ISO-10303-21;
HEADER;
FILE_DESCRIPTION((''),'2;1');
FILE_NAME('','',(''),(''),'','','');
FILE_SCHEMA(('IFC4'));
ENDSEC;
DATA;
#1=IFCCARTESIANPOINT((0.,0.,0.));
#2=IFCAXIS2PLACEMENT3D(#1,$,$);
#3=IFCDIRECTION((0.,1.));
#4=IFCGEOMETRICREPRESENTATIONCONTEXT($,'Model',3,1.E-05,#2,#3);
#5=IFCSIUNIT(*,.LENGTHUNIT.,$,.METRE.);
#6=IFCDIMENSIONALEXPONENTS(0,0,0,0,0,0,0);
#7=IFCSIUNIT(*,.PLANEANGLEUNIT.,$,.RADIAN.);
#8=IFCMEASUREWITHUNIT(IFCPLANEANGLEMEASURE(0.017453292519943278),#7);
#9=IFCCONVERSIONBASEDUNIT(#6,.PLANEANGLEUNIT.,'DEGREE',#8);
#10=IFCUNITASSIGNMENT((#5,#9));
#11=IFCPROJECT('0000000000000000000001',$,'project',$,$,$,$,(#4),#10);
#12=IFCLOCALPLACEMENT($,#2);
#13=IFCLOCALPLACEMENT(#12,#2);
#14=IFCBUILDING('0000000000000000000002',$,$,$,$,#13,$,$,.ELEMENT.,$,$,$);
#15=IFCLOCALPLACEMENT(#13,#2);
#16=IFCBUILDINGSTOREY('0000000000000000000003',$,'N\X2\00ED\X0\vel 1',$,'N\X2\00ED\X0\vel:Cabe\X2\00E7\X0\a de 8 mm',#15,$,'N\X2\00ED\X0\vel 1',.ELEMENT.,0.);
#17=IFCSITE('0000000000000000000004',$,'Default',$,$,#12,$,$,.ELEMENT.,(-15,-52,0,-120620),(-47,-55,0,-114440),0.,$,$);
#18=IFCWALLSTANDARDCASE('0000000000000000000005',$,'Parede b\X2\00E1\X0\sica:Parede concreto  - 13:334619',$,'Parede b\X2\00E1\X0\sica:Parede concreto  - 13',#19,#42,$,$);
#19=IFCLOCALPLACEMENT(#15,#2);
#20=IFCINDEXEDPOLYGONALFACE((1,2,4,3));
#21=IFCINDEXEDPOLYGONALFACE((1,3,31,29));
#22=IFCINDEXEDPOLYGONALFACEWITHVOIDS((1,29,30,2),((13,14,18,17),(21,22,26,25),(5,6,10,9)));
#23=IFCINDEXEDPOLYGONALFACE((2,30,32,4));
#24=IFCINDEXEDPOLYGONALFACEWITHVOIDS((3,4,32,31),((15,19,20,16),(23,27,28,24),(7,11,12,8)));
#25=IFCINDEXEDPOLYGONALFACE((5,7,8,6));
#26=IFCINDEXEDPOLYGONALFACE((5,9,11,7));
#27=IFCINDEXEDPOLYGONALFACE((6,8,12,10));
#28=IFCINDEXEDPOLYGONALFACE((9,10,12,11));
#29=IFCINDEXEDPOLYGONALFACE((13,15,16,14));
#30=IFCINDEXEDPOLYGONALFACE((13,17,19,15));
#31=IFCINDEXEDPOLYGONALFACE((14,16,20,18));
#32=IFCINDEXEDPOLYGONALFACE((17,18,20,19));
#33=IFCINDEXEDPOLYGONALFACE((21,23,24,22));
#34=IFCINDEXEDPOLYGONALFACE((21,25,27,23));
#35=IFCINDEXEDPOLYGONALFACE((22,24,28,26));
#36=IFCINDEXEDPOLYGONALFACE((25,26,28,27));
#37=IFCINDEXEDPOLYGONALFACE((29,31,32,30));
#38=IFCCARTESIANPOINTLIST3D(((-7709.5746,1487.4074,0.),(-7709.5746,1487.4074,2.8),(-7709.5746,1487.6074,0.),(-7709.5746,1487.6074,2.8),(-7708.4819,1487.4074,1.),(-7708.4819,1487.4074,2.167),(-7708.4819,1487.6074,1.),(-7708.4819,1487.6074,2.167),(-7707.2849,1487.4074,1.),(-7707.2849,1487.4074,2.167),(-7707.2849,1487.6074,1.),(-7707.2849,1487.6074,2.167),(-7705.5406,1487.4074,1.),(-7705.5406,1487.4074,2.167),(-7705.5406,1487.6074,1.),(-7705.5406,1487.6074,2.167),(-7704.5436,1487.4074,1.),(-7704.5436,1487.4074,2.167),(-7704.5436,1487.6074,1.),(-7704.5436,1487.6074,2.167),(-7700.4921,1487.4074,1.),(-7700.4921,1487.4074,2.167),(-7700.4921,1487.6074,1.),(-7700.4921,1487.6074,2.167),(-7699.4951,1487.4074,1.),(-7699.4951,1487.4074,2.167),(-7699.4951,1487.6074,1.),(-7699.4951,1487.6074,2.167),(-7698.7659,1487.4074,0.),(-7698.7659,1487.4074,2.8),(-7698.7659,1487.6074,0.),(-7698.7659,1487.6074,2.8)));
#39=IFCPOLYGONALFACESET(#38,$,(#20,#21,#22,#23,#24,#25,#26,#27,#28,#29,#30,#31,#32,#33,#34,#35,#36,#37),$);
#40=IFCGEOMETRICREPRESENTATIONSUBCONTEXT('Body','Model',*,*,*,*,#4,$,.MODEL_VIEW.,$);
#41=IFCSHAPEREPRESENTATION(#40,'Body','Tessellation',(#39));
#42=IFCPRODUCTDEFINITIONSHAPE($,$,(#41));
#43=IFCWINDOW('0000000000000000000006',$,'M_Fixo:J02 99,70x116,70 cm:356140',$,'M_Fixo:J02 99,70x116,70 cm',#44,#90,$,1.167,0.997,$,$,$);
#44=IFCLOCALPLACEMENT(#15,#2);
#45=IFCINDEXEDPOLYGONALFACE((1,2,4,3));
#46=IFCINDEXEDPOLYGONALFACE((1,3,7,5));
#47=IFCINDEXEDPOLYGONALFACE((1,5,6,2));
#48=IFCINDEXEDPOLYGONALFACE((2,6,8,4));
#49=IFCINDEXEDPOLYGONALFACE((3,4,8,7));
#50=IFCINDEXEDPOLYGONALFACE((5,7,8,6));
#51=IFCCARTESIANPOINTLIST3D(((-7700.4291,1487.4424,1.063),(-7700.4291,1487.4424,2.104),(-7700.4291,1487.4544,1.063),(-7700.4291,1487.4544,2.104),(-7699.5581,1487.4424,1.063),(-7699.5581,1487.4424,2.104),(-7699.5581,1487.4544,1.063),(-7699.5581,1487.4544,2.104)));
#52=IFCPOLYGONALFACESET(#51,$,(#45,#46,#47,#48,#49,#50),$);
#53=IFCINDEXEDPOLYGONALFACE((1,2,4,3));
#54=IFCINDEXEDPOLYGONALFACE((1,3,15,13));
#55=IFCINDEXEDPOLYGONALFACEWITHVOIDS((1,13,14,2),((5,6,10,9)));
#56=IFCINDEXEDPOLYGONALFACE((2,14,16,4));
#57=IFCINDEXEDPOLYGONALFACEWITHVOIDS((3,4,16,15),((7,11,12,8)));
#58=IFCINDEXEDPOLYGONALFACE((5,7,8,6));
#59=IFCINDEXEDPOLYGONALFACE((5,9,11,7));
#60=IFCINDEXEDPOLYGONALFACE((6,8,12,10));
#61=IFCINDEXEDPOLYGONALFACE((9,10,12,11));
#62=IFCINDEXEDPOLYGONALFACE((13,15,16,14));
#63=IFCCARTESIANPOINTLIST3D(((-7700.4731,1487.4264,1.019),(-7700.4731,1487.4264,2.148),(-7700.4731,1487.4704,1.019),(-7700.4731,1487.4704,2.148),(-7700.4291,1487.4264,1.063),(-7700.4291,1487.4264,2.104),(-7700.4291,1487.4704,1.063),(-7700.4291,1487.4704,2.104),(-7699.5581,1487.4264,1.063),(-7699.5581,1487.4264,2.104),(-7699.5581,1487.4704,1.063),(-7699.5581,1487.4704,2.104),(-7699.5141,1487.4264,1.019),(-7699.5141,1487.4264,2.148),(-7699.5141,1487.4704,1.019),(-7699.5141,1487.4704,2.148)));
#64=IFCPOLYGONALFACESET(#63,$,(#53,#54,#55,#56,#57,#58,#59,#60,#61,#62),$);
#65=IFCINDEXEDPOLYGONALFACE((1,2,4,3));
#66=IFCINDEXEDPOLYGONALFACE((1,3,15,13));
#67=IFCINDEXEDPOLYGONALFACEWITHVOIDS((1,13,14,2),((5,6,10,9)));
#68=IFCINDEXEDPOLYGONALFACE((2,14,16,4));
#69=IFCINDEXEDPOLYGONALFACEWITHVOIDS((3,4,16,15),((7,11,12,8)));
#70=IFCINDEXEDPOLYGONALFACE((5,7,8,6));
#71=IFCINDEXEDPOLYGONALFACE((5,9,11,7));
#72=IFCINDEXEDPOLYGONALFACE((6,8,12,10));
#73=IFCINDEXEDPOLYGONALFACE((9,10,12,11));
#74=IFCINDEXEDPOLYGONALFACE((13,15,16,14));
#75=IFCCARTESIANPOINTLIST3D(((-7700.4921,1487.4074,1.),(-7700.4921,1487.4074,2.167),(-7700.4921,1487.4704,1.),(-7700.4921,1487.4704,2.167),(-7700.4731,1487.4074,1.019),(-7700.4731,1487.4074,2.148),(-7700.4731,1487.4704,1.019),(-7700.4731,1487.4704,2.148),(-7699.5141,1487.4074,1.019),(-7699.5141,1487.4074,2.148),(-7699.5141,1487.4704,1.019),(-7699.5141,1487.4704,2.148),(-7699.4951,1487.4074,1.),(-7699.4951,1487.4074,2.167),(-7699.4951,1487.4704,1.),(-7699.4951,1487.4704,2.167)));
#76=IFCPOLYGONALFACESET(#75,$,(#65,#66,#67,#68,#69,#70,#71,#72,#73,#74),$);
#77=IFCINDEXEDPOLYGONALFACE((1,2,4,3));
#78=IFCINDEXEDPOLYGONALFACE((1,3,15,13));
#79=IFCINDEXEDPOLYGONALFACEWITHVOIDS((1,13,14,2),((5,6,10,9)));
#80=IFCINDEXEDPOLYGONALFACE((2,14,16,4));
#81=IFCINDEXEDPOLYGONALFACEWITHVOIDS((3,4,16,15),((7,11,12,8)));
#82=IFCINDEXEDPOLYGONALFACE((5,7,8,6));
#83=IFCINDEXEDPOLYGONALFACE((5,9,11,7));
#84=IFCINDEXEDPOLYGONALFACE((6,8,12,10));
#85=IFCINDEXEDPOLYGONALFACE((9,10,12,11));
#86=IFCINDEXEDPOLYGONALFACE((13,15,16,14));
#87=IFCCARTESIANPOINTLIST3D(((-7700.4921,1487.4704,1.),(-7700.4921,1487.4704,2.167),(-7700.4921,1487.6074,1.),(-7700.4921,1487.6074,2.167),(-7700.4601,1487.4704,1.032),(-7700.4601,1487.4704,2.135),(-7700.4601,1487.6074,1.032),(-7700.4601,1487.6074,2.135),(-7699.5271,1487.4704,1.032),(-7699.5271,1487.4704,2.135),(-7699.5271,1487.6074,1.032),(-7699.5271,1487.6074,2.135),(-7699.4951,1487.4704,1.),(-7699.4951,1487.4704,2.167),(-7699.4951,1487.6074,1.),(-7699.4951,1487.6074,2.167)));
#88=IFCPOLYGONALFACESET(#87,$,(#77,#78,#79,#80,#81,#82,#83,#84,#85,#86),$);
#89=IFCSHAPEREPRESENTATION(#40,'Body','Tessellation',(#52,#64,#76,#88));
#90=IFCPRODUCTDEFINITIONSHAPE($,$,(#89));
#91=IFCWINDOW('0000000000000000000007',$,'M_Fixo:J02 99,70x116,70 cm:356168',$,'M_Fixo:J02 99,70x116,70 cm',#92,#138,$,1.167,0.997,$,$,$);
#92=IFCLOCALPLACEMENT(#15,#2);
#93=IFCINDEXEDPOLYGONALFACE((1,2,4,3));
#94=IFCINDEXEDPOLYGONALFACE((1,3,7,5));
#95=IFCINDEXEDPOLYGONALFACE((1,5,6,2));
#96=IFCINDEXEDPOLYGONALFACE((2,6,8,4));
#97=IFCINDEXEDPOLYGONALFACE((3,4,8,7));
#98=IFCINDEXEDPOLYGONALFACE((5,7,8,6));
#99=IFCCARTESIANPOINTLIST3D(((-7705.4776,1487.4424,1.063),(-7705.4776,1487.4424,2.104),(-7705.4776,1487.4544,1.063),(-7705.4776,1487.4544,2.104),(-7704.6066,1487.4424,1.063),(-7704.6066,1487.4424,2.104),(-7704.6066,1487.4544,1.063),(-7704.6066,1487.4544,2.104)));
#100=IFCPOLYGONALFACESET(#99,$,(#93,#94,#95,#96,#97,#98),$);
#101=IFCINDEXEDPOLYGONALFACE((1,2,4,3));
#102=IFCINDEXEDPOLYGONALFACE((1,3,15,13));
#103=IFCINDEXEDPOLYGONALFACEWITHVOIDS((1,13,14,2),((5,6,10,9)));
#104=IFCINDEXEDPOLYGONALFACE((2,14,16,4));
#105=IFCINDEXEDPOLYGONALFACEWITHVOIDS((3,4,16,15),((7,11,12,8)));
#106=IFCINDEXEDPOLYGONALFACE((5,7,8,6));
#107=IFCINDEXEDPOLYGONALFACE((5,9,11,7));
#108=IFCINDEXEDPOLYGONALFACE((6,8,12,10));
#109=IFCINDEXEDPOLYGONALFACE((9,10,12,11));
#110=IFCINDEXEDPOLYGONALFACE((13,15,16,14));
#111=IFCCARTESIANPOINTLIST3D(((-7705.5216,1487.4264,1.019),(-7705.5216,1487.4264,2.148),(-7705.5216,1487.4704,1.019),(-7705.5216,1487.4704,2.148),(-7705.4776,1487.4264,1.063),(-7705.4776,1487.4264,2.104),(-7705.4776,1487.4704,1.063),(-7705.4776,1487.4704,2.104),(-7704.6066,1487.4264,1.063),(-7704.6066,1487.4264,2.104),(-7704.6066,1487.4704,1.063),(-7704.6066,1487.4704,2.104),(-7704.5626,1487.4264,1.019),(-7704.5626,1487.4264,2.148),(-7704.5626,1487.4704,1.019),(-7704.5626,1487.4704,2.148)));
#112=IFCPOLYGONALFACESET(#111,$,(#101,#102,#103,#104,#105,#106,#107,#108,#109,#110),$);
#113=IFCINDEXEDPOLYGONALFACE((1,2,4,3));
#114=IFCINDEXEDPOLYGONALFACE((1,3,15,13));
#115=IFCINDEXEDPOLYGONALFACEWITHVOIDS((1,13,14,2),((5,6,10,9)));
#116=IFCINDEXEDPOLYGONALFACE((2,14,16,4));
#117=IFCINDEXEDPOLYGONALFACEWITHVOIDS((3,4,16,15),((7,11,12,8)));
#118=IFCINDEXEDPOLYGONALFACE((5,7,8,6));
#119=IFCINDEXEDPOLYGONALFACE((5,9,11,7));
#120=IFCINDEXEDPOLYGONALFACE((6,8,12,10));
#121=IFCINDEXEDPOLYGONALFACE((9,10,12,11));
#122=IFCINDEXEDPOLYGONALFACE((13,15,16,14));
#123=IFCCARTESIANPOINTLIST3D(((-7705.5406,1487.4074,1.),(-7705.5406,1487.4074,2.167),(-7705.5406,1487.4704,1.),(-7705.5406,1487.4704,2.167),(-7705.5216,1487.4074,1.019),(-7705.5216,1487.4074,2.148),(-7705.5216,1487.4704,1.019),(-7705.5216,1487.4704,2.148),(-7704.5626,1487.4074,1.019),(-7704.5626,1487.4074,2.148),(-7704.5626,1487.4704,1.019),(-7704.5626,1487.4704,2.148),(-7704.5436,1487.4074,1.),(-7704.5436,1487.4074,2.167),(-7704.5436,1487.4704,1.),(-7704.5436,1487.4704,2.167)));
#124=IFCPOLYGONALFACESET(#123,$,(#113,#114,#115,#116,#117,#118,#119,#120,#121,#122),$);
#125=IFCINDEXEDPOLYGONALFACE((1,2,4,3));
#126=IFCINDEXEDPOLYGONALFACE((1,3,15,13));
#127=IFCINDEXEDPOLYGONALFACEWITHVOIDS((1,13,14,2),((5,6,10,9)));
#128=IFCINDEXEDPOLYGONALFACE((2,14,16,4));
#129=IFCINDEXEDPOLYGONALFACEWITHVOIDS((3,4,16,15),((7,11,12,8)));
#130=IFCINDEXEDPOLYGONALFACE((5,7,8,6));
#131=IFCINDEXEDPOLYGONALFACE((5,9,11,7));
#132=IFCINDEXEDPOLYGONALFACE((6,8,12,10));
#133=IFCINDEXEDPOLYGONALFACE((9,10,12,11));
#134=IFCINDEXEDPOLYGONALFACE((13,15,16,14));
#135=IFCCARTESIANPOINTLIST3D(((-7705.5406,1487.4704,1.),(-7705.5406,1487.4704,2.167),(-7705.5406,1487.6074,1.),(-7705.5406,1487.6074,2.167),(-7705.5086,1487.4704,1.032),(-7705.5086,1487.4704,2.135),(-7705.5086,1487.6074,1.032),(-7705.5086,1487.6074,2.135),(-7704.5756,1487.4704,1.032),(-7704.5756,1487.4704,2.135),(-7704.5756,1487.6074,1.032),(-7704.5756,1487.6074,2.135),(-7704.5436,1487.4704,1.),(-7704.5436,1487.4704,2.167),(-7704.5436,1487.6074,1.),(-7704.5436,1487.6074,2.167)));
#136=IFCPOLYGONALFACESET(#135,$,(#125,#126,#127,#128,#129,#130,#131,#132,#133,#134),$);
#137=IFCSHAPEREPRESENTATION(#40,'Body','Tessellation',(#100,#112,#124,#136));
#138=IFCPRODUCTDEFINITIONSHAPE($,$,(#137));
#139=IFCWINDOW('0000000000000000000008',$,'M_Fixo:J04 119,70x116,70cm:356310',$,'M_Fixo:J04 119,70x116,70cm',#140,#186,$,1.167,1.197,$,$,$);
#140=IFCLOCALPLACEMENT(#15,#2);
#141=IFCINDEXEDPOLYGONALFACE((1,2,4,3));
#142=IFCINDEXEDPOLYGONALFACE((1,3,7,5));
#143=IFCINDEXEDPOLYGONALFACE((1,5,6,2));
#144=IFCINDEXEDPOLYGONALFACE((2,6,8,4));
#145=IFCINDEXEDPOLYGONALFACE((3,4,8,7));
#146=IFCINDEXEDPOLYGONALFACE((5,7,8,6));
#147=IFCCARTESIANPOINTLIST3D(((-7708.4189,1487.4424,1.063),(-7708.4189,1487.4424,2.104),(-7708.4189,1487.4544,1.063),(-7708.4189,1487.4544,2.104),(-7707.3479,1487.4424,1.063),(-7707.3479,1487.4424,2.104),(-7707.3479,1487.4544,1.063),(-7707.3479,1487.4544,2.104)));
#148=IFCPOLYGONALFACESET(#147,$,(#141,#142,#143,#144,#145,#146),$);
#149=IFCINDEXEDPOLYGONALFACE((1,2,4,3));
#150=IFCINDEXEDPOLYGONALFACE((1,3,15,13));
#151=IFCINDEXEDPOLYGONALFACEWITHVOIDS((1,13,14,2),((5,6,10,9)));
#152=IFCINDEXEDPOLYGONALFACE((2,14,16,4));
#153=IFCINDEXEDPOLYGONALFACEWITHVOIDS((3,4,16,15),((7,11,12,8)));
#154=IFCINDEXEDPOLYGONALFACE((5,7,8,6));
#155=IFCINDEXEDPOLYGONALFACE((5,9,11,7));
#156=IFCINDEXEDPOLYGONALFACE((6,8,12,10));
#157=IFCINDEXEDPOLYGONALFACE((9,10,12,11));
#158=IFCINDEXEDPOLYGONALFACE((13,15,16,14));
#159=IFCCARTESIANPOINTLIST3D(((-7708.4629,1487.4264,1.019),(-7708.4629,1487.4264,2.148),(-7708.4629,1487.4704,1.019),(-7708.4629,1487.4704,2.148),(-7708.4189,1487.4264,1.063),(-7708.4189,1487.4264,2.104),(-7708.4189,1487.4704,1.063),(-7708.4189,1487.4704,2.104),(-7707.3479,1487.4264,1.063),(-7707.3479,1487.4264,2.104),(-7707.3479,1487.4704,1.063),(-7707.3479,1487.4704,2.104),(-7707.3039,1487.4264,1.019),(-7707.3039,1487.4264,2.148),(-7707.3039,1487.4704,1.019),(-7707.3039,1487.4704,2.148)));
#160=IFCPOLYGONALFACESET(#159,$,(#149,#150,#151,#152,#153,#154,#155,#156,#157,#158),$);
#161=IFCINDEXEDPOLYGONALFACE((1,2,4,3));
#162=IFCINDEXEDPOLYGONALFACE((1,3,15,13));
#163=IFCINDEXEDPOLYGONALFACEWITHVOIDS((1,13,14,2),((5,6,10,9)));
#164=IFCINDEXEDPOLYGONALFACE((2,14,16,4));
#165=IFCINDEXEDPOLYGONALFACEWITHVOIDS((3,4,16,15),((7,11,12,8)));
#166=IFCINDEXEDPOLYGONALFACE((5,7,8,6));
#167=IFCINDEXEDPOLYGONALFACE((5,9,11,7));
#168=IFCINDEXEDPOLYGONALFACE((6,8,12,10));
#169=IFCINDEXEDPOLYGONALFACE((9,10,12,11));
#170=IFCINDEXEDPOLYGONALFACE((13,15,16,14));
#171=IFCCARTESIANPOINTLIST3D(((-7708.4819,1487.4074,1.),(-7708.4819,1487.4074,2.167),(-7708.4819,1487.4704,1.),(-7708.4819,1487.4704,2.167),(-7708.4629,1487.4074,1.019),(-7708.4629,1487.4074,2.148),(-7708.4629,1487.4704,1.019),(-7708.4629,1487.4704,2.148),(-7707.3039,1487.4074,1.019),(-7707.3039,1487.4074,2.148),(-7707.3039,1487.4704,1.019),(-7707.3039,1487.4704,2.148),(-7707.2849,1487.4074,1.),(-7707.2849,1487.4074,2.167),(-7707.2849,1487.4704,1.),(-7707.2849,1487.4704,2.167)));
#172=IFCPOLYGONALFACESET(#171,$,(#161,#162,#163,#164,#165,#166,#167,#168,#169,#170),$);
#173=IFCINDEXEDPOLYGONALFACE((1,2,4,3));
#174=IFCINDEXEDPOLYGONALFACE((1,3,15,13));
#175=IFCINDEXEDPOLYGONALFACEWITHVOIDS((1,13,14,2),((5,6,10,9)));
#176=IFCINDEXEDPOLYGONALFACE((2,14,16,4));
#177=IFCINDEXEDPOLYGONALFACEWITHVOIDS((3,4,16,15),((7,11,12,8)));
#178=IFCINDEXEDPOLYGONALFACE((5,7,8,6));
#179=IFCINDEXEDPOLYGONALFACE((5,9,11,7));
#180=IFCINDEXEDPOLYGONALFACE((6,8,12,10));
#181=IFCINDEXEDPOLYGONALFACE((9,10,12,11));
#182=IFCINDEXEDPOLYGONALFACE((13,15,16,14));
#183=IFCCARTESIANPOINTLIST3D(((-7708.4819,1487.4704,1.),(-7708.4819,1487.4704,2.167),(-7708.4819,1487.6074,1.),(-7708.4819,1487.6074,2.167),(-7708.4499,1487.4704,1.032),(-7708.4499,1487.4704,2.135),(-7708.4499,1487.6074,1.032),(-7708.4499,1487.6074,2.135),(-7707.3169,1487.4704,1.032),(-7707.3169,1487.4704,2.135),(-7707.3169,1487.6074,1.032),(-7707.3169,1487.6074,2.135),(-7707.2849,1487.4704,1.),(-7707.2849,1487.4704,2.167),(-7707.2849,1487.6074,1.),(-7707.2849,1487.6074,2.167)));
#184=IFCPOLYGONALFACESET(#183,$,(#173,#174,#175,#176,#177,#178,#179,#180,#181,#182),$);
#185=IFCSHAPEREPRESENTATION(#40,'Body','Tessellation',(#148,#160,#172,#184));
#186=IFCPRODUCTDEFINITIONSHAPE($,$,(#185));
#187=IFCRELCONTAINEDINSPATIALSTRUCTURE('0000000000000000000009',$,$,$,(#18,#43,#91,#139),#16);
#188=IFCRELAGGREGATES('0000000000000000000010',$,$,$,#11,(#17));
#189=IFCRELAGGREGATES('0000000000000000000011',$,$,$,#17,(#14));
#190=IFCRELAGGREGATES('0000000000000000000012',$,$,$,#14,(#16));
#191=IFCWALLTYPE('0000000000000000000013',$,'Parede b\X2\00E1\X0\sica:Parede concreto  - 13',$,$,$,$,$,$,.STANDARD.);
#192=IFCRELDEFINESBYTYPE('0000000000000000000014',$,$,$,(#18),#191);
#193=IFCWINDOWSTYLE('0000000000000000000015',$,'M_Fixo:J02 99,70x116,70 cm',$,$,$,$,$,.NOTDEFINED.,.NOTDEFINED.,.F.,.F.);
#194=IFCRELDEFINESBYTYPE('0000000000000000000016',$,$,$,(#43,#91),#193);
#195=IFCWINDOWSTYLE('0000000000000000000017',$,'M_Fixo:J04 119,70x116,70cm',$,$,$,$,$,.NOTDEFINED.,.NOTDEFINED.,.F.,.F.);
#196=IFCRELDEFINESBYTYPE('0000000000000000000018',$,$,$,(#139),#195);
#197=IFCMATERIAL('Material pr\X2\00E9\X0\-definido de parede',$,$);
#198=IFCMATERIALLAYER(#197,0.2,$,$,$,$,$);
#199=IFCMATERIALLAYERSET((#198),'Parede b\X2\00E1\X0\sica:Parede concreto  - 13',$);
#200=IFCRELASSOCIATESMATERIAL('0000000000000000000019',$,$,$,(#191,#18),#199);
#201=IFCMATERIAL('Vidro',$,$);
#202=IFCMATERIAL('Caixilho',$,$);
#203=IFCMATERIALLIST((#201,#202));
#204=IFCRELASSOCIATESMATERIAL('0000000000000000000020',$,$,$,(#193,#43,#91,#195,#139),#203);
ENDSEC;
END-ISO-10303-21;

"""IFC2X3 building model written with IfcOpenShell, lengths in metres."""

from ifc_helpers import new_model, entity, si_unit, converted_unit, direction, frame, frame_2d, origin, place, context, subcontext, project, spatial, polyline, rectangle, outline, extrude, source, transform, mapped, material, material_list, layer, layer_set, layer_usage, type_object, type_shapes, element, fill, save


model = new_model("IFC2X3")

# Units and contexts
model_context = context("Model", 3, precision=1e-05, world=origin(), true_north=direction((0.0, 1.0)))
body_context = subcontext(model_context, "Body", "Model", "MODEL_VIEW")
ifc_project = project(units=[si_unit("LENGTHUNIT", "METRE"), converted_unit("PLANEANGLEUNIT", "DEGREE", entity("IfcPlaneAngleMeasure", 0.017453292519943278), si_unit("PLANEANGLEUNIT", "RADIAN"), dimensions=[0, 0, 0, 0, 0, 0, 0])], contexts=[model_context])

# Site, building, storey
site_placement = place(None, origin())
site = spatial("IfcSite", under=ifc_project, at=site_placement, Name="Default", CompositionType="ELEMENT", RefLatitude=(-15, -52, 0, -120620), RefLongitude=(-47, -55, 0, -114440), RefElevation=0.0)
building_placement = place(site_placement, origin())
building = spatial("IfcBuilding", under=site, at=building_placement, CompositionType="ELEMENT")
storey_placement = place(building_placement, origin())
storey = spatial("IfcBuildingStorey", under=building, at=storey_placement, Name="Nível 1", ObjectType="Nível:Cabeça de 8 mm", LongName="Nível 1", CompositionType="ELEMENT", Elevation=0.0)

# Shared definitions
ifc_material_1 = material(Name="Material pré-definido de parede")
ifc_layer = layer(ifc_material_1, 0.2)
ifc_layer_set = layer_set([ifc_layer], Name="Parede básica:Parede concreto  - 13")
wall_type = type_object("IfcWallType", Name="Parede básica:Parede concreto  - 13", PredefinedType="STANDARD", material=ifc_layer_set)

# Wall, openings, windows
ifc_layer_usage_1 = layer_usage(ifc_layer_set, "AXIS2", "NEGATIVE", 0.1)
wall_1_placement = place(storey_placement, frame((-7698.7659, 1487.5074, 0.0), z_axis=(0.0, 0.0, 1.0), x_axis=(-1.0, 0.0, 0.0)))
wall_1 = element("IfcWallStandardCase", 1, at=wall_1_placement, inside=storey, type_object=wall_type, material=ifc_layer_usage_1, Name="Parede básica:Parede concreto  - 13:334619", ObjectType="Parede básica:Parede concreto  - 13", context=body_context, shape_type="SweptSolid", body=[
    extrude(rectangle(XDim=10.8087, YDim=0.2, at=frame_2d((5.4043, 0.0), x_axis=(-1.0, 0.0))), origin(), (0.0, 0.0, 1.0), 2.8),
])
opening_1_placement = place(wall_1_placement, frame((0.7292, -0.1, 1.0)))
opening_1 = element("IfcOpeningElement", 2, at=opening_1_placement, cuts=wall_1, ObjectType="Opening", context=body_context, shape_type="SweptSolid", body=[
    extrude(rectangle(XDim=1.167, YDim=0.997, at=frame_2d((0.5835, 0.4985), x_axis=(1.0, 0.0))), frame((0.0, 0.0, 0.0), z_axis=(0.0, 1.0, 0.0), x_axis=(0.0, 0.0, 1.0)), (0.0, 0.0, 1.0), 0.2),
])
opening_2_placement = place(wall_1_placement, frame((5.7777, -0.1, 1.0)))
opening_2 = element("IfcOpeningElement", 3, at=opening_2_placement, cuts=wall_1, ObjectType="Opening", context=body_context, shape_type="SweptSolid", body=[
    extrude(rectangle(XDim=1.167, YDim=0.997, at=frame_2d((0.5835, 0.4985), x_axis=(1.0, 0.0))), frame((0.0, 0.0, 0.0), z_axis=(0.0, 1.0, 0.0), x_axis=(0.0, 0.0, 1.0)), (0.0, 0.0, 1.0), 0.2),
])
opening_3_placement = place(wall_1_placement, frame((8.5189, -0.1, 1.0)))
opening_3 = element("IfcOpeningElement", 4, at=opening_3_placement, cuts=wall_1, ObjectType="Opening", context=body_context, shape_type="SweptSolid", body=[
    extrude(rectangle(XDim=1.167, YDim=1.197, at=frame_2d((0.5835, 0.5985), x_axis=(1.0, 0.0))), frame((0.0, 0.0, 0.0), z_axis=(0.0, 1.0, 0.0), x_axis=(0.0, 0.0, 1.0)), (0.0, 0.0, 1.0), 0.2),
])
ifc_material_2 = material(Name="Vidro")
ifc_material_3 = material(Name="Caixilho")
ifc_material_list = material_list([ifc_material_2, ifc_material_3])
window_style_1 = type_object("IfcWindowStyle", Name="M_Fixo:J02 99,70x116,70 cm", ConstructionType="NOTDEFINED", OperationType="NOTDEFINED", ParameterTakesPrecedence=False, Sizeable=False, material=ifc_material_list)
shared_shape_1 = source(origin(), body_context, "Body", "SweptSolid", [
    extrude(rectangle(XDim=0.012, YDim=0.871, at=frame_2d((0.0, 0.0), x_axis=(1.0, 0.0))), frame((0.4985, 0.159, 0.063), z_axis=(0.0, 0.0, 1.0), x_axis=(0.0, -1.0, 0.0)), (0.0, 0.0, 1.0), 1.041),
    extrude(outline(polyline([(-0.4795, -0.5645), (0.4795, -0.5645), (0.4795, 0.5645), (-0.4795, 0.5645), (-0.4795, -0.5645)]), holes=[polyline([(-0.4355, -0.5205), (-0.4355, 0.5205), (0.4355, 0.5205), (0.4355, -0.5205), (-0.4355, -0.5205)])]), frame((0.4985, 0.137, 0.5835), z_axis=(0.0, 1.0, 0.0), x_axis=(1.0, 0.0, 0.0)), (0.0, 0.0, 1.0), 0.044),
    extrude(outline(polyline([(-0.4985, -0.5835), (0.4985, -0.5835), (0.4985, 0.5835), (-0.4985, 0.5835), (-0.4985, -0.5835)]), holes=[polyline([(-0.4795, -0.5645), (-0.4795, 0.5645), (0.4795, 0.5645), (0.4795, -0.5645), (-0.4795, -0.5645)])]), frame((0.4985, 0.137, 0.5835), z_axis=(0.0, 1.0, 0.0), x_axis=(1.0, 0.0, 0.0)), (0.0, 0.0, 1.0), 0.063),
    extrude(outline(polyline([(-0.4985, -0.5835), (0.4985, -0.5835), (0.4985, 0.5835), (-0.4985, 0.5835), (-0.4985, -0.5835)]), holes=[polyline([(-0.4665, -0.5515), (-0.4665, 0.5515), (0.4665, 0.5515), (0.4665, -0.5515), (-0.4665, -0.5515)])]), frame((0.4985, 0.0, 0.5835), z_axis=(0.0, 1.0, 0.0), x_axis=(1.0, 0.0, 0.0)), (0.0, 0.0, 1.0), 0.137),
])
type_shapes(window_style_1, [shared_shape_1])
window_1_placement = place(opening_1_placement, origin())
window_1 = element("IfcWindow", 5, at=window_1_placement, inside=storey, type_object=window_style_1, material=ifc_material_list, Name="M_Fixo:J02 99,70x116,70 cm:356140", ObjectType="M_Fixo:J02 99,70x116,70 cm", OverallHeight=1.167, OverallWidth=0.997, context=body_context, shape_type="MappedRepresentation", body=[
    mapped(shared_shape_1, transform((0.0, 0.0, 0.0), scale=1.0)),
])
fill(opening_1, window_1)
window_2_placement = place(opening_2_placement, origin())
window_2 = element("IfcWindow", 6, at=window_2_placement, inside=storey, type_object=window_style_1, material=ifc_material_list, Name="M_Fixo:J02 99,70x116,70 cm:356168", ObjectType="M_Fixo:J02 99,70x116,70 cm", OverallHeight=1.167, OverallWidth=0.997, context=body_context, shape_type="MappedRepresentation", body=[
    mapped(shared_shape_1, transform((0.0, 0.0, 0.0), scale=1.0)),
])
fill(opening_2, window_2)
window_style_2 = type_object("IfcWindowStyle", Name="M_Fixo:J04 119,70x116,70cm", ConstructionType="NOTDEFINED", OperationType="NOTDEFINED", ParameterTakesPrecedence=False, Sizeable=False, material=ifc_material_list)
shared_shape_2 = source(origin(), body_context, "Body", "SweptSolid", [
    extrude(rectangle(XDim=0.012, YDim=1.071, at=frame_2d((0.0, 0.0), x_axis=(1.0, 0.0))), frame((0.5985, 0.159, 0.063), z_axis=(0.0, 0.0, 1.0), x_axis=(0.0, -1.0, 0.0)), (0.0, 0.0, 1.0), 1.041),
    extrude(outline(polyline([(-0.5795, -0.5645), (0.5795, -0.5645), (0.5795, 0.5645), (-0.5795, 0.5645), (-0.5795, -0.5645)]), holes=[polyline([(-0.5355, -0.5205), (-0.5355, 0.5205), (0.5355, 0.5205), (0.5355, -0.5205), (-0.5355, -0.5205)])]), frame((0.5985, 0.137, 0.5835), z_axis=(0.0, 1.0, 0.0), x_axis=(1.0, 0.0, 0.0)), (0.0, 0.0, 1.0), 0.044),
    extrude(outline(polyline([(-0.5985, -0.5835), (0.5985, -0.5835), (0.5985, 0.5835), (-0.5985, 0.5835), (-0.5985, -0.5835)]), holes=[polyline([(-0.5795, -0.5645), (-0.5795, 0.5645), (0.5795, 0.5645), (0.5795, -0.5645), (-0.5795, -0.5645)])]), frame((0.5985, 0.137, 0.5835), z_axis=(0.0, 1.0, 0.0), x_axis=(1.0, 0.0, 0.0)), (0.0, 0.0, 1.0), 0.063),
    extrude(outline(polyline([(-0.5985, -0.5835), (0.5985, -0.5835), (0.5985, 0.5835), (-0.5985, 0.5835), (-0.5985, -0.5835)]), holes=[polyline([(-0.5665, -0.5515), (-0.5665, 0.5515), (0.5665, 0.5515), (0.5665, -0.5515), (-0.5665, -0.5515)])]), frame((0.5985, 0.0, 0.5835), z_axis=(0.0, 1.0, 0.0), x_axis=(1.0, 0.0, 0.0)), (0.0, 0.0, 1.0), 0.137),
])
type_shapes(window_style_2, [shared_shape_2])
window_3_placement = place(opening_3_placement, origin())
window_3 = element("IfcWindow", 7, at=window_3_placement, inside=storey, type_object=window_style_2, material=ifc_material_list, Name="M_Fixo:J04 119,70x116,70cm:356310", ObjectType="M_Fixo:J04 119,70x116,70cm", OverallHeight=1.167, OverallWidth=1.197, context=body_context, shape_type="MappedRepresentation", body=[
    mapped(shared_shape_2, transform((0.0, 0.0, 0.0), scale=1.0)),
])
fill(opening_3, window_3)

save(model, "model.ifc")
